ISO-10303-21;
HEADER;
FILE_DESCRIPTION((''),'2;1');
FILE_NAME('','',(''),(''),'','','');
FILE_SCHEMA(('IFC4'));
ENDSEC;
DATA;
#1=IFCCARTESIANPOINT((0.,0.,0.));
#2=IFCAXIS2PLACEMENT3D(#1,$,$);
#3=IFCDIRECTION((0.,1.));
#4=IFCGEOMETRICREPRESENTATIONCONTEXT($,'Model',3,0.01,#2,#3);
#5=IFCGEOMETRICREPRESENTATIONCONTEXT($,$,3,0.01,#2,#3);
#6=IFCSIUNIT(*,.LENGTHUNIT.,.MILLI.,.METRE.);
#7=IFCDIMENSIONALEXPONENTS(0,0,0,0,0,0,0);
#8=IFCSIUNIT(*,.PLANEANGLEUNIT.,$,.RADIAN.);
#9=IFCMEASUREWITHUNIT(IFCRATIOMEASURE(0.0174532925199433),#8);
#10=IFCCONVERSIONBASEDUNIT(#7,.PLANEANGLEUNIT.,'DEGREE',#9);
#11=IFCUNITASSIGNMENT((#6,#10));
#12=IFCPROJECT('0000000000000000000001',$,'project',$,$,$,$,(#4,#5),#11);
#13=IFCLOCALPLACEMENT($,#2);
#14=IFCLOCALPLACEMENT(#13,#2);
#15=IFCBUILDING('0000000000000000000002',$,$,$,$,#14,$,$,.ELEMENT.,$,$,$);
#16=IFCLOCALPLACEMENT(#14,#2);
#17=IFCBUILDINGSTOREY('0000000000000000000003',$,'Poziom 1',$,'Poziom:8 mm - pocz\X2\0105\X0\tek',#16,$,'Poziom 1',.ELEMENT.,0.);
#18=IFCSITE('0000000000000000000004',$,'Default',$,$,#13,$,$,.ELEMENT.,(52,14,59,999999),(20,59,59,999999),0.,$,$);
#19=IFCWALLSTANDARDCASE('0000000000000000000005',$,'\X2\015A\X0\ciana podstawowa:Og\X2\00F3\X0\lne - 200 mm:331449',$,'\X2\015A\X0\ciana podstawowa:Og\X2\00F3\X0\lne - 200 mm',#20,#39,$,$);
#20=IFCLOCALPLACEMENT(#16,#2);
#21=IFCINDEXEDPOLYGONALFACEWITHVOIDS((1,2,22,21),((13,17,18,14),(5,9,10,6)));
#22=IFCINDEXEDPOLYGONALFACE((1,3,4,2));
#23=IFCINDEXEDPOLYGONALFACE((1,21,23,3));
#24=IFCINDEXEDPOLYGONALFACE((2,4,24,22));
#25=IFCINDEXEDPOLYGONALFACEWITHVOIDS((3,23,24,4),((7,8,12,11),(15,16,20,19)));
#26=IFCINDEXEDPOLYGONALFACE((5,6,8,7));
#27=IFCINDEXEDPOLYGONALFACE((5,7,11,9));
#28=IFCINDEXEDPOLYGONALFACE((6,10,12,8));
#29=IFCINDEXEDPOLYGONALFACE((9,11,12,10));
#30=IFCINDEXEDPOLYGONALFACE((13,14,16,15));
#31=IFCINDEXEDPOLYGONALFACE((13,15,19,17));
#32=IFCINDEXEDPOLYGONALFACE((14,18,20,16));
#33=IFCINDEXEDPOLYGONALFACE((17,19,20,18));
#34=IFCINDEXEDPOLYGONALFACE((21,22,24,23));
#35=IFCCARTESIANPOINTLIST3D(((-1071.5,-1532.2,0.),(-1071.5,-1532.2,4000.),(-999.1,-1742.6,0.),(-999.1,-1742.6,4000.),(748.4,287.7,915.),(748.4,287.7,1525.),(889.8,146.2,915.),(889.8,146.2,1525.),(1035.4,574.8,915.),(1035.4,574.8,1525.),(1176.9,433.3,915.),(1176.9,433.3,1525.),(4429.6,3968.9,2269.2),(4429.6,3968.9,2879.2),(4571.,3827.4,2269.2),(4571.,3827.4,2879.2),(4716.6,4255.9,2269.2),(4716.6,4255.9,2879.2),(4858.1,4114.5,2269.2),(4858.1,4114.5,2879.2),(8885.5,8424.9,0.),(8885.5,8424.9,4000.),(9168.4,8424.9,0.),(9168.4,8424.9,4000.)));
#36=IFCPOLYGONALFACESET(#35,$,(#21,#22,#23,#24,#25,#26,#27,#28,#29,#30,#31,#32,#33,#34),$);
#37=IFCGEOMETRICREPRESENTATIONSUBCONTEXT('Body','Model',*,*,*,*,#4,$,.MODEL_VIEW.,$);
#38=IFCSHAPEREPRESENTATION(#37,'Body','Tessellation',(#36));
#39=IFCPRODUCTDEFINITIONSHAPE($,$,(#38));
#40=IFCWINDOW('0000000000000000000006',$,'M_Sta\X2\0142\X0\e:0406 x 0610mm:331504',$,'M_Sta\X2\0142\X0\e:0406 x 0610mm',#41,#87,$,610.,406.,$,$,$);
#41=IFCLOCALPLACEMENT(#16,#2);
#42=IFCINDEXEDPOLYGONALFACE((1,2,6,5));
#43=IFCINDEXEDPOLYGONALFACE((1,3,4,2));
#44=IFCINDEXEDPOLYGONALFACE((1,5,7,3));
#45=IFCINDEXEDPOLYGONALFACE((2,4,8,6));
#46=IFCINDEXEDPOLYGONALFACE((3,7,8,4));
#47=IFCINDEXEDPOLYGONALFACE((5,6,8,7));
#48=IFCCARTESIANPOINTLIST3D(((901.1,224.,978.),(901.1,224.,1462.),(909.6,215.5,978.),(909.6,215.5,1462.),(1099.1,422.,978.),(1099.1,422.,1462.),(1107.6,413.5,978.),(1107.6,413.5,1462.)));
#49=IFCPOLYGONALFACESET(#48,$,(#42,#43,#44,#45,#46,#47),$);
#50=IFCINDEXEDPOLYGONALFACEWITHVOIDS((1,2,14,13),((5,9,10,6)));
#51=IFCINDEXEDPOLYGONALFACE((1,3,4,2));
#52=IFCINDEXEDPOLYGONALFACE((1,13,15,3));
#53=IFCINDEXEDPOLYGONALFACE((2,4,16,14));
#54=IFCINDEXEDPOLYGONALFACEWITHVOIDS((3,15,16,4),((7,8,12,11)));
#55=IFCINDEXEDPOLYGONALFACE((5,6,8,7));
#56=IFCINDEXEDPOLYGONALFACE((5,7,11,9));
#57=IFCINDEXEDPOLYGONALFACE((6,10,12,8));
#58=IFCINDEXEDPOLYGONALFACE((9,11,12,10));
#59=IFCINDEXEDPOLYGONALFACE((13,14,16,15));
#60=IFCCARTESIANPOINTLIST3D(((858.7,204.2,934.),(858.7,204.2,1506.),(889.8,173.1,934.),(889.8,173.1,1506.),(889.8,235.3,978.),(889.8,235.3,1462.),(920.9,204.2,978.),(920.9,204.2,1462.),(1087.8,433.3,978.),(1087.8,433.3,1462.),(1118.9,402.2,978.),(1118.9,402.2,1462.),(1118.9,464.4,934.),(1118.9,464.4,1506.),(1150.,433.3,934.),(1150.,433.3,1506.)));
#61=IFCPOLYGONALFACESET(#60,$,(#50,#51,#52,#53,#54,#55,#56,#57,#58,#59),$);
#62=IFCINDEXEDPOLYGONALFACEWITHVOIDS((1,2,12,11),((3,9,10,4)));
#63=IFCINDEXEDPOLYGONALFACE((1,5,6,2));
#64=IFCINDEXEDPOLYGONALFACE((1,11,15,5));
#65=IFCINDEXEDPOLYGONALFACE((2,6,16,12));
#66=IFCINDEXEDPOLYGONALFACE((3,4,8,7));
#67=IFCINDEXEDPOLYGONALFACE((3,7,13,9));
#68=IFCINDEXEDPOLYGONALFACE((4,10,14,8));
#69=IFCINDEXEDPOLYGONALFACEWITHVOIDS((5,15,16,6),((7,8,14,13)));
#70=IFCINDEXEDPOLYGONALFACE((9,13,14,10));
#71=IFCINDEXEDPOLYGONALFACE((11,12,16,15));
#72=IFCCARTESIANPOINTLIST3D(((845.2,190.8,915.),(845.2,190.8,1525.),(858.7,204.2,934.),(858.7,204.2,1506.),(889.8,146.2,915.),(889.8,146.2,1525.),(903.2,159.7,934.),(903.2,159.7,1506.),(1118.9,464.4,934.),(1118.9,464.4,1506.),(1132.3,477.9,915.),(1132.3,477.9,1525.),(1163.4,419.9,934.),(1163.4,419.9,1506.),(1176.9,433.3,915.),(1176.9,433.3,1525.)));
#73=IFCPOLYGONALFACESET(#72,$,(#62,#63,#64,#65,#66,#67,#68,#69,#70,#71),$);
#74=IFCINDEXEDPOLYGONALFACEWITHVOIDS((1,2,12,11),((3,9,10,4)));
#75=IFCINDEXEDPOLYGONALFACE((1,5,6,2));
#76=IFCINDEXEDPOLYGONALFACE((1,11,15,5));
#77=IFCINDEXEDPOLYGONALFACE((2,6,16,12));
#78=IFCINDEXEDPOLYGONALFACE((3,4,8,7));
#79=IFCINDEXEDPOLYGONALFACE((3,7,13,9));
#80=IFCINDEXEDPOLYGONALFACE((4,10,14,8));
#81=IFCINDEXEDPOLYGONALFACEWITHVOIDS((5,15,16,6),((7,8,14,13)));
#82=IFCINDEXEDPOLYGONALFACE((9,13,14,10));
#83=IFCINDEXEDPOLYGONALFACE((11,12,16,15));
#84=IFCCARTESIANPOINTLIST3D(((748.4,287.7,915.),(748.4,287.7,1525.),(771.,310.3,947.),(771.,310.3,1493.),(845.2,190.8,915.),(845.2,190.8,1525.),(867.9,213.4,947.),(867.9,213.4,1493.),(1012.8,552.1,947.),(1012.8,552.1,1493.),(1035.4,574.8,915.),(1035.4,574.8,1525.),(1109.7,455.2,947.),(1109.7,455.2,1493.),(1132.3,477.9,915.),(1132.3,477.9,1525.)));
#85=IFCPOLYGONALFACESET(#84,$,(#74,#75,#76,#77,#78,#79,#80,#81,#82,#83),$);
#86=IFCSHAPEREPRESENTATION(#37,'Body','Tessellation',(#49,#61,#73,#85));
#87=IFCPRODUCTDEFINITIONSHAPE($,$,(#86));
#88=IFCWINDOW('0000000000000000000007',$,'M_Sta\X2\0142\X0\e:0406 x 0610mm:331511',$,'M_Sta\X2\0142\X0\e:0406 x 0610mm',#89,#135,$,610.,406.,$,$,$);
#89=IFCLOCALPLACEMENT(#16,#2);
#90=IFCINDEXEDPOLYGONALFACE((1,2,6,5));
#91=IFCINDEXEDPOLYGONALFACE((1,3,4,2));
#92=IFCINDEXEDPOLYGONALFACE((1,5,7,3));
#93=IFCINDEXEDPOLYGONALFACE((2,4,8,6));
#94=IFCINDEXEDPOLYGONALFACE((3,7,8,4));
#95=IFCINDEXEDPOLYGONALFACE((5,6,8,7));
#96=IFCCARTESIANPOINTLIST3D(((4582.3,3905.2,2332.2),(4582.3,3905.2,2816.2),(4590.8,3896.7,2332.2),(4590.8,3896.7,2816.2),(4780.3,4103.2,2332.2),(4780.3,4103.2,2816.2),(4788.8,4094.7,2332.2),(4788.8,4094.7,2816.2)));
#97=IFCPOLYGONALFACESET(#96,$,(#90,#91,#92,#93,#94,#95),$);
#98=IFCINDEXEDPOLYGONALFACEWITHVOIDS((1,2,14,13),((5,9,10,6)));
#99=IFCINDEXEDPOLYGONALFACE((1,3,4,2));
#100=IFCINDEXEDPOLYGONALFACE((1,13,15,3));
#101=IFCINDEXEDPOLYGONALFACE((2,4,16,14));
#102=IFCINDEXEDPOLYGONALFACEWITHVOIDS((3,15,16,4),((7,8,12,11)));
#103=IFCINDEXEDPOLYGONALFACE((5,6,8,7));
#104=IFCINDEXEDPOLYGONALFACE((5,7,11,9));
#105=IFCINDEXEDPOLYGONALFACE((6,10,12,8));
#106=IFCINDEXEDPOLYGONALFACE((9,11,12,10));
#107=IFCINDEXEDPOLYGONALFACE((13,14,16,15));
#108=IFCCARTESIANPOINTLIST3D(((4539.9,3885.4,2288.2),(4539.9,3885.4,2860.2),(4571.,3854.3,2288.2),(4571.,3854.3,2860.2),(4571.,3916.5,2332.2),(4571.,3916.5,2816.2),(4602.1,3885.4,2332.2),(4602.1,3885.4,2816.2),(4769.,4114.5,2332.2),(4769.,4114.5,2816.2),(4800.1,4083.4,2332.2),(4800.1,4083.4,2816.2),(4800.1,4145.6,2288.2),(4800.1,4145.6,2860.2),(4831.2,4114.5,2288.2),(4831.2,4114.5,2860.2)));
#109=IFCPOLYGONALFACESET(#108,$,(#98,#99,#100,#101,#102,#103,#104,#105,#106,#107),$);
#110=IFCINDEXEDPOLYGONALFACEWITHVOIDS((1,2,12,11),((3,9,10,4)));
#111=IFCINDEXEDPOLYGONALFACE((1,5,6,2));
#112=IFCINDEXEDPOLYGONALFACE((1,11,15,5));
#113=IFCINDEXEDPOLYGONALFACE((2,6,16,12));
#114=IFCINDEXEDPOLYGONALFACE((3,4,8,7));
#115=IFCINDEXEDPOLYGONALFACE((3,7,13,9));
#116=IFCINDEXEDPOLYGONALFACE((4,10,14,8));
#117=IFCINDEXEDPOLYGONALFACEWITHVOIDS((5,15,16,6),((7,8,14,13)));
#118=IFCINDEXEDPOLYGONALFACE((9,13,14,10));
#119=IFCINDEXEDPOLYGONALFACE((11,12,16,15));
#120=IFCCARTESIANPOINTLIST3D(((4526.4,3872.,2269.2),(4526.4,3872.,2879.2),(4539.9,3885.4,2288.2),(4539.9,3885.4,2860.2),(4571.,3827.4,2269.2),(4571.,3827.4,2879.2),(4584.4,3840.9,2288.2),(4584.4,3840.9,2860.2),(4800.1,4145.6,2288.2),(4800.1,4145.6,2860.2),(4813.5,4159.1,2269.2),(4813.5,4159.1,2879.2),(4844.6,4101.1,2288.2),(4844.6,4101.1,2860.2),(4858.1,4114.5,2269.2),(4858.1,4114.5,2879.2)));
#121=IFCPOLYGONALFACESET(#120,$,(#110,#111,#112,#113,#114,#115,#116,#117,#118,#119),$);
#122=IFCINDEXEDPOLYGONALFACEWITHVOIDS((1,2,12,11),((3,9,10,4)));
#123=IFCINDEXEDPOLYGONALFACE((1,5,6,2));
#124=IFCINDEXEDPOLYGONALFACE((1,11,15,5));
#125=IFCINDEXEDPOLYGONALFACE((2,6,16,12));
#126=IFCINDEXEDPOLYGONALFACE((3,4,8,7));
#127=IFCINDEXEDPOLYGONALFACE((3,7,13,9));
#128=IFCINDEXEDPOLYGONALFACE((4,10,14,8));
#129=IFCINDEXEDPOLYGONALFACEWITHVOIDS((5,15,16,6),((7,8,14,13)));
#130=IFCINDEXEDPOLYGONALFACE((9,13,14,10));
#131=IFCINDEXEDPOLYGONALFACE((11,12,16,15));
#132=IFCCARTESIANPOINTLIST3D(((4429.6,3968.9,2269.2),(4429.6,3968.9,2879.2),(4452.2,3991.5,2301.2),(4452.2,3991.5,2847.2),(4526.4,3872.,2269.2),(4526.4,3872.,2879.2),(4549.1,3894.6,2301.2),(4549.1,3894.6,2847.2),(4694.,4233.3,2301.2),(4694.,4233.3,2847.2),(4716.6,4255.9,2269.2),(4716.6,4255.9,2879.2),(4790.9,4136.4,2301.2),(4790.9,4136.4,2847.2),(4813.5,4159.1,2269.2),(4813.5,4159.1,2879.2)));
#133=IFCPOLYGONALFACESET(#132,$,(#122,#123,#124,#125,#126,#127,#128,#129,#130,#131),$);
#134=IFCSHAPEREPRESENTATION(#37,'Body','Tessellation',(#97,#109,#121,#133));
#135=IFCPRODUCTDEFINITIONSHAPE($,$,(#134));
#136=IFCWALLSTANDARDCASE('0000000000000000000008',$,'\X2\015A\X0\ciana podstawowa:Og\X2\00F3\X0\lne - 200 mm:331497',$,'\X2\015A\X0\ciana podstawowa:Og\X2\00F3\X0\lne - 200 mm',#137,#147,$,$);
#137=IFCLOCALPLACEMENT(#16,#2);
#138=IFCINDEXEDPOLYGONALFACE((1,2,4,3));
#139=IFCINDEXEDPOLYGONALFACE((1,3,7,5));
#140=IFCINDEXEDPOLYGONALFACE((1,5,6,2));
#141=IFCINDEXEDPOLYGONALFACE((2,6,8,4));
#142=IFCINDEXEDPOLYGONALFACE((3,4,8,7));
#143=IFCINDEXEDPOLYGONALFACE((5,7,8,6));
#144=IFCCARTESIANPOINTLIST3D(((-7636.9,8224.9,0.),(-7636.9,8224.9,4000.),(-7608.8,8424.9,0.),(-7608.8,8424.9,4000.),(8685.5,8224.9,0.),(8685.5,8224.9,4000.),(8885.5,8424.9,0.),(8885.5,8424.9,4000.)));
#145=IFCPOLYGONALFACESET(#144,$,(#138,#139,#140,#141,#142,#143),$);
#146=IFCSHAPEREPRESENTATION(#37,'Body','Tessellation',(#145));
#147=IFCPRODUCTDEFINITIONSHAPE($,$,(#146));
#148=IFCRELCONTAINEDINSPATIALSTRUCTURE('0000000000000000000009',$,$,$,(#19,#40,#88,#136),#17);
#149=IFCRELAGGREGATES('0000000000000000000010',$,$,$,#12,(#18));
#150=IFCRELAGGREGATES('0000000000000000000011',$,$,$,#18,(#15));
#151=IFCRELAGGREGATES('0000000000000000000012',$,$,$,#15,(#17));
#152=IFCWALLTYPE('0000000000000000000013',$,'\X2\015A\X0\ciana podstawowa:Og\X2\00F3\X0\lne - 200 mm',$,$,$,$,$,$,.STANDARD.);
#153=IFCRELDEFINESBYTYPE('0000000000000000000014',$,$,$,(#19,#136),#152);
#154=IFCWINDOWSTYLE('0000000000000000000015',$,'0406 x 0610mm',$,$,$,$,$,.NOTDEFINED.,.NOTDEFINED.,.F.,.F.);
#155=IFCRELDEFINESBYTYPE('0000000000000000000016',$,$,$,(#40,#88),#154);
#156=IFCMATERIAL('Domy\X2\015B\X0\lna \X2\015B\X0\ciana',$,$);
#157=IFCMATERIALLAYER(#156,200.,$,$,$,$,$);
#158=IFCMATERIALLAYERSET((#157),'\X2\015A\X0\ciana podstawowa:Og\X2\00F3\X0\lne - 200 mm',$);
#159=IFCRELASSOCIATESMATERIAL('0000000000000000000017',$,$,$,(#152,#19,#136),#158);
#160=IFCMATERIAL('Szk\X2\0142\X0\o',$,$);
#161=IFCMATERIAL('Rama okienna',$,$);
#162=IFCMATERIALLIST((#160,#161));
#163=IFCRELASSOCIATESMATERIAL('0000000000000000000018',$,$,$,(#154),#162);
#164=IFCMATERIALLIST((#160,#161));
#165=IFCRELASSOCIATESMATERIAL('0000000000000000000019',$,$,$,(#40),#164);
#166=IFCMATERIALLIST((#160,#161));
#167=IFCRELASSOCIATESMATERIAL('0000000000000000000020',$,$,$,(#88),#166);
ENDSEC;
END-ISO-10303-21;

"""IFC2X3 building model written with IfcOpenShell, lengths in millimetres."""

from ifc_helpers import new_model, entity, si_unit, converted_unit, direction, frame, frame_2d, origin, place, context, subcontext, project, spatial, polyline, rectangle, outline, extrude, clip, halfspace, source, transform, mapped, material, material_list, layer, layer_set, layer_usage, type_object, type_shapes, element, fill, save


model = new_model("IFC2X3")

# Units and contexts
model_context = context("Model", 3, precision=0.01, world=origin(), true_north=direction((0.0, 1.0)))
context_of_model = context(None, 3, precision=0.01, world=origin(), true_north=direction((0.0, 1.0)))
body_context = subcontext(model_context, "Body", "Model", "MODEL_VIEW")
ifc_project = project(units=[si_unit("LENGTHUNIT", "METRE", prefix="MILLI"), converted_unit("PLANEANGLEUNIT", "DEGREE", entity("IfcRatioMeasure", 0.0174532925199433), si_unit("PLANEANGLEUNIT", "RADIAN"), dimensions=[0, 0, 0, 0, 0, 0, 0])], contexts=[model_context, context_of_model])

# Site, building, storey
site_placement = place(None, origin())
site = spatial("IfcSite", under=ifc_project, at=site_placement, Name="Default", CompositionType="ELEMENT", RefLatitude=(52, 14, 59, 999999), RefLongitude=(20, 59, 59, 999999), RefElevation=0.0)
building_placement = place(site_placement, origin())
building = spatial("IfcBuilding", under=site, at=building_placement, CompositionType="ELEMENT")
storey_placement = place(building_placement, origin())
storey = spatial("IfcBuildingStorey", under=building, at=storey_placement, Name="Poziom 1", ObjectType="Poziom:8 mm - początek", LongName="Poziom 1", CompositionType="ELEMENT", Elevation=0.0)

# Shared definitions
ifc_material_1 = material(Name="Domyślna ściana")
ifc_layer_1 = layer(ifc_material_1, 200.0)
ifc_layer_set_1 = layer_set([ifc_layer_1], Name="Ściana podstawowa:Ogólne - 200 mm")
wall_type = type_object("IfcWallType", Name="Ściana podstawowa:Ogólne - 200 mm", PredefinedType="STANDARD", material=ifc_layer_set_1)

# Wall, openings, windows
ifc_layer_usage_1 = layer_usage(ifc_layer_set_1, "AXIS2", "NEGATIVE", 100.0)
wall_1_placement = place(storey_placement, frame((-1069.8, -1671.9, 0.0), z_axis=(0.0, 0.0, 1.0), x_axis=(0.707107, 0.707107, 0.0)))
wall_1 = element("IfcWallStandardCase", 1, at=wall_1_placement, inside=storey, type_object=wall_type, material=ifc_layer_usage_1, Name="Ściana podstawowa:Ogólne - 200 mm:331449", ObjectType="Ściana podstawowa:Ogólne - 200 mm", context=body_context, shape_type="Clipping", body=[
    clip(extrude(outline(polyline([(14378.9, -100.0), (14178.9, 100.0), (13896.1, 100.0), (97.5, 100.0), (0.0, -100.0), (14378.9, -100.0)])), origin(), (0.0, 0.0, 1.0), 4000.0), halfspace(origin(), True)),
])
opening_1_placement = place(wall_1_placement, frame((3077.2, 100.0, 915.0)))
opening_1 = element("IfcOpeningElement", 2, at=opening_1_placement, cuts=wall_1, ObjectType="Opening", context=body_context, shape_type="SweptSolid", body=[
    extrude(rectangle(XDim=610.0, YDim=406.0, at=frame_2d((305.0, 203.0), x_axis=(1.0, 0.0))), frame((0.0, 0.0, 0.0), z_axis=(0.0, -1.0, 0.0), x_axis=(0.0, 0.0, 1.0)), (0.0, 0.0, 1.0), 200.0),
])
opening_2_placement = place(wall_1_placement, frame((8283.2, 100.0, 2269.2)))
opening_2 = element("IfcOpeningElement", 3, at=opening_2_placement, cuts=wall_1, ObjectType="Opening", context=body_context, shape_type="SweptSolid", body=[
    extrude(rectangle(XDim=610.0, YDim=406.0, at=frame_2d((305.0, 203.0), x_axis=(1.0, 0.0))), frame((0.0, 0.0, 0.0), z_axis=(0.0, -1.0, 0.0), x_axis=(0.0, 0.0, 1.0)), (0.0, 0.0, 1.0), 200.0),
])
ifc_material_2 = material(Name="Szkło")
ifc_material_3 = material(Name="Rama okienna")
ifc_material_list_1 = material_list([ifc_material_2, ifc_material_3])
ifc_material_list_2 = material_list([ifc_material_2, ifc_material_3])
window_style = type_object("IfcWindowStyle", Name="0406 x 0610mm", ConstructionType="NOTDEFINED", OperationType="NOTDEFINED", ParameterTakesPrecedence=False, Sizeable=False, material=ifc_material_list_2)
shared_shape_1 = source(origin(), body_context, "Body", "SweptSolid", [
    extrude(rectangle(XDim=12.0, YDim=280.0, at=frame_2d((0.0, 0.0), x_axis=(1.0, 0.0))), frame((203.0, 159.0, 63.0), z_axis=(0.0, 0.0, 1.0), x_axis=(0.0, -1.0, 0.0)), (0.0, 0.0, 1.0), 484.0),
    extrude(outline(polyline([(-184.0, -286.0), (184.0, -286.0), (184.0, 286.0), (-184.0, 286.0), (-184.0, -286.0)]), holes=[polyline([(-140.0, -242.0), (-140.0, 242.0), (140.0, 242.0), (140.0, -242.0), (-140.0, -242.0)])]), frame((203.0, 137.0, 305.0), z_axis=(0.0, 1.0, 0.0), x_axis=(1.0, 0.0, 0.0)), (0.0, 0.0, 1.0), 44.0),
    extrude(outline(polyline([(-203.0, -305.0), (203.0, -305.0), (203.0, 305.0), (-203.0, 305.0), (-203.0, -305.0)]), holes=[polyline([(-184.0, -286.0), (-184.0, 286.0), (184.0, 286.0), (184.0, -286.0), (-184.0, -286.0)])]), frame((203.0, 137.0, 305.0), z_axis=(0.0, 1.0, 0.0), x_axis=(1.0, 0.0, 0.0)), (0.0, 0.0, 1.0), 63.0),
    extrude(outline(polyline([(-203.0, -305.0), (203.0, -305.0), (203.0, 305.0), (-203.0, 305.0), (-203.0, -305.0)]), holes=[polyline([(-171.0, -273.0), (-171.0, 273.0), (171.0, 273.0), (171.0, -273.0), (-171.0, -273.0)])]), frame((203.0, 0.0, 305.0), z_axis=(0.0, 1.0, 0.0), x_axis=(1.0, 0.0, 0.0)), (0.0, 0.0, 1.0), 137.0),
])
type_shapes(window_style, [shared_shape_1])
window_1_placement = place(opening_1_placement, frame((0.0, 0.0, 0.0), z_axis=(0.0, 0.0, 1.0), x_axis=(-1.0, 0.0, 0.0)))
window_1 = element("IfcWindow", 4, at=window_1_placement, inside=storey, type_object=window_style, material=ifc_material_list_1, Name="M_Stałe:0406 x 0610mm:331504", ObjectType="M_Stałe:0406 x 0610mm", OverallHeight=610.0, OverallWidth=406.0, context=body_context, shape_type="MappedRepresentation", body=[
    mapped(shared_shape_1, transform((0.0, 0.0, 0.0), scale=1.0)),
])
fill(opening_1, window_1)
ifc_material_list_3 = material_list([ifc_material_2, ifc_material_3])
window_2_placement = place(opening_2_placement, frame((0.0, 0.0, 0.0), z_axis=(0.0, 0.0, 1.0), x_axis=(-1.0, 0.0, 0.0)))
window_2 = element("IfcWindow", 5, at=window_2_placement, inside=storey, type_object=window_style, material=ifc_material_list_3, Name="M_Stałe:0406 x 0610mm:331511", ObjectType="M_Stałe:0406 x 0610mm", OverallHeight=610.0, OverallWidth=406.0, context=body_context, shape_type="MappedRepresentation", body=[
    mapped(shared_shape_1, transform((0.0, 0.0, 0.0), scale=1.0)),
])
fill(opening_2, window_2)

# Wall
ifc_layer_usage_2 = layer_usage(ifc_layer_set_1, "AXIS2", "NEGATIVE", 100.0)
wall_2_placement = place(storey_placement, frame((8885.5, 8324.9, 0.0), z_axis=(0.0, 0.0, 1.0), x_axis=(-1.0, 0.0, 0.0)))
element("IfcWallStandardCase", 6, at=wall_2_placement, inside=storey, type_object=wall_type, material=ifc_layer_usage_2, Name="Ściana podstawowa:Ogólne - 200 mm:331497", ObjectType="Ściana podstawowa:Ogólne - 200 mm", context=body_context, shape_type="Clipping", body=[
    clip(extrude(outline(polyline([(16494.3, -100.0), (16522.4, 100.0), (200.0, 100.0), (0.0, -100.0), (16494.3, -100.0)])), origin(), (0.0, 0.0, 1.0), 4000.0), halfspace(origin(), True)),
])

save(model, "model.ifc")
